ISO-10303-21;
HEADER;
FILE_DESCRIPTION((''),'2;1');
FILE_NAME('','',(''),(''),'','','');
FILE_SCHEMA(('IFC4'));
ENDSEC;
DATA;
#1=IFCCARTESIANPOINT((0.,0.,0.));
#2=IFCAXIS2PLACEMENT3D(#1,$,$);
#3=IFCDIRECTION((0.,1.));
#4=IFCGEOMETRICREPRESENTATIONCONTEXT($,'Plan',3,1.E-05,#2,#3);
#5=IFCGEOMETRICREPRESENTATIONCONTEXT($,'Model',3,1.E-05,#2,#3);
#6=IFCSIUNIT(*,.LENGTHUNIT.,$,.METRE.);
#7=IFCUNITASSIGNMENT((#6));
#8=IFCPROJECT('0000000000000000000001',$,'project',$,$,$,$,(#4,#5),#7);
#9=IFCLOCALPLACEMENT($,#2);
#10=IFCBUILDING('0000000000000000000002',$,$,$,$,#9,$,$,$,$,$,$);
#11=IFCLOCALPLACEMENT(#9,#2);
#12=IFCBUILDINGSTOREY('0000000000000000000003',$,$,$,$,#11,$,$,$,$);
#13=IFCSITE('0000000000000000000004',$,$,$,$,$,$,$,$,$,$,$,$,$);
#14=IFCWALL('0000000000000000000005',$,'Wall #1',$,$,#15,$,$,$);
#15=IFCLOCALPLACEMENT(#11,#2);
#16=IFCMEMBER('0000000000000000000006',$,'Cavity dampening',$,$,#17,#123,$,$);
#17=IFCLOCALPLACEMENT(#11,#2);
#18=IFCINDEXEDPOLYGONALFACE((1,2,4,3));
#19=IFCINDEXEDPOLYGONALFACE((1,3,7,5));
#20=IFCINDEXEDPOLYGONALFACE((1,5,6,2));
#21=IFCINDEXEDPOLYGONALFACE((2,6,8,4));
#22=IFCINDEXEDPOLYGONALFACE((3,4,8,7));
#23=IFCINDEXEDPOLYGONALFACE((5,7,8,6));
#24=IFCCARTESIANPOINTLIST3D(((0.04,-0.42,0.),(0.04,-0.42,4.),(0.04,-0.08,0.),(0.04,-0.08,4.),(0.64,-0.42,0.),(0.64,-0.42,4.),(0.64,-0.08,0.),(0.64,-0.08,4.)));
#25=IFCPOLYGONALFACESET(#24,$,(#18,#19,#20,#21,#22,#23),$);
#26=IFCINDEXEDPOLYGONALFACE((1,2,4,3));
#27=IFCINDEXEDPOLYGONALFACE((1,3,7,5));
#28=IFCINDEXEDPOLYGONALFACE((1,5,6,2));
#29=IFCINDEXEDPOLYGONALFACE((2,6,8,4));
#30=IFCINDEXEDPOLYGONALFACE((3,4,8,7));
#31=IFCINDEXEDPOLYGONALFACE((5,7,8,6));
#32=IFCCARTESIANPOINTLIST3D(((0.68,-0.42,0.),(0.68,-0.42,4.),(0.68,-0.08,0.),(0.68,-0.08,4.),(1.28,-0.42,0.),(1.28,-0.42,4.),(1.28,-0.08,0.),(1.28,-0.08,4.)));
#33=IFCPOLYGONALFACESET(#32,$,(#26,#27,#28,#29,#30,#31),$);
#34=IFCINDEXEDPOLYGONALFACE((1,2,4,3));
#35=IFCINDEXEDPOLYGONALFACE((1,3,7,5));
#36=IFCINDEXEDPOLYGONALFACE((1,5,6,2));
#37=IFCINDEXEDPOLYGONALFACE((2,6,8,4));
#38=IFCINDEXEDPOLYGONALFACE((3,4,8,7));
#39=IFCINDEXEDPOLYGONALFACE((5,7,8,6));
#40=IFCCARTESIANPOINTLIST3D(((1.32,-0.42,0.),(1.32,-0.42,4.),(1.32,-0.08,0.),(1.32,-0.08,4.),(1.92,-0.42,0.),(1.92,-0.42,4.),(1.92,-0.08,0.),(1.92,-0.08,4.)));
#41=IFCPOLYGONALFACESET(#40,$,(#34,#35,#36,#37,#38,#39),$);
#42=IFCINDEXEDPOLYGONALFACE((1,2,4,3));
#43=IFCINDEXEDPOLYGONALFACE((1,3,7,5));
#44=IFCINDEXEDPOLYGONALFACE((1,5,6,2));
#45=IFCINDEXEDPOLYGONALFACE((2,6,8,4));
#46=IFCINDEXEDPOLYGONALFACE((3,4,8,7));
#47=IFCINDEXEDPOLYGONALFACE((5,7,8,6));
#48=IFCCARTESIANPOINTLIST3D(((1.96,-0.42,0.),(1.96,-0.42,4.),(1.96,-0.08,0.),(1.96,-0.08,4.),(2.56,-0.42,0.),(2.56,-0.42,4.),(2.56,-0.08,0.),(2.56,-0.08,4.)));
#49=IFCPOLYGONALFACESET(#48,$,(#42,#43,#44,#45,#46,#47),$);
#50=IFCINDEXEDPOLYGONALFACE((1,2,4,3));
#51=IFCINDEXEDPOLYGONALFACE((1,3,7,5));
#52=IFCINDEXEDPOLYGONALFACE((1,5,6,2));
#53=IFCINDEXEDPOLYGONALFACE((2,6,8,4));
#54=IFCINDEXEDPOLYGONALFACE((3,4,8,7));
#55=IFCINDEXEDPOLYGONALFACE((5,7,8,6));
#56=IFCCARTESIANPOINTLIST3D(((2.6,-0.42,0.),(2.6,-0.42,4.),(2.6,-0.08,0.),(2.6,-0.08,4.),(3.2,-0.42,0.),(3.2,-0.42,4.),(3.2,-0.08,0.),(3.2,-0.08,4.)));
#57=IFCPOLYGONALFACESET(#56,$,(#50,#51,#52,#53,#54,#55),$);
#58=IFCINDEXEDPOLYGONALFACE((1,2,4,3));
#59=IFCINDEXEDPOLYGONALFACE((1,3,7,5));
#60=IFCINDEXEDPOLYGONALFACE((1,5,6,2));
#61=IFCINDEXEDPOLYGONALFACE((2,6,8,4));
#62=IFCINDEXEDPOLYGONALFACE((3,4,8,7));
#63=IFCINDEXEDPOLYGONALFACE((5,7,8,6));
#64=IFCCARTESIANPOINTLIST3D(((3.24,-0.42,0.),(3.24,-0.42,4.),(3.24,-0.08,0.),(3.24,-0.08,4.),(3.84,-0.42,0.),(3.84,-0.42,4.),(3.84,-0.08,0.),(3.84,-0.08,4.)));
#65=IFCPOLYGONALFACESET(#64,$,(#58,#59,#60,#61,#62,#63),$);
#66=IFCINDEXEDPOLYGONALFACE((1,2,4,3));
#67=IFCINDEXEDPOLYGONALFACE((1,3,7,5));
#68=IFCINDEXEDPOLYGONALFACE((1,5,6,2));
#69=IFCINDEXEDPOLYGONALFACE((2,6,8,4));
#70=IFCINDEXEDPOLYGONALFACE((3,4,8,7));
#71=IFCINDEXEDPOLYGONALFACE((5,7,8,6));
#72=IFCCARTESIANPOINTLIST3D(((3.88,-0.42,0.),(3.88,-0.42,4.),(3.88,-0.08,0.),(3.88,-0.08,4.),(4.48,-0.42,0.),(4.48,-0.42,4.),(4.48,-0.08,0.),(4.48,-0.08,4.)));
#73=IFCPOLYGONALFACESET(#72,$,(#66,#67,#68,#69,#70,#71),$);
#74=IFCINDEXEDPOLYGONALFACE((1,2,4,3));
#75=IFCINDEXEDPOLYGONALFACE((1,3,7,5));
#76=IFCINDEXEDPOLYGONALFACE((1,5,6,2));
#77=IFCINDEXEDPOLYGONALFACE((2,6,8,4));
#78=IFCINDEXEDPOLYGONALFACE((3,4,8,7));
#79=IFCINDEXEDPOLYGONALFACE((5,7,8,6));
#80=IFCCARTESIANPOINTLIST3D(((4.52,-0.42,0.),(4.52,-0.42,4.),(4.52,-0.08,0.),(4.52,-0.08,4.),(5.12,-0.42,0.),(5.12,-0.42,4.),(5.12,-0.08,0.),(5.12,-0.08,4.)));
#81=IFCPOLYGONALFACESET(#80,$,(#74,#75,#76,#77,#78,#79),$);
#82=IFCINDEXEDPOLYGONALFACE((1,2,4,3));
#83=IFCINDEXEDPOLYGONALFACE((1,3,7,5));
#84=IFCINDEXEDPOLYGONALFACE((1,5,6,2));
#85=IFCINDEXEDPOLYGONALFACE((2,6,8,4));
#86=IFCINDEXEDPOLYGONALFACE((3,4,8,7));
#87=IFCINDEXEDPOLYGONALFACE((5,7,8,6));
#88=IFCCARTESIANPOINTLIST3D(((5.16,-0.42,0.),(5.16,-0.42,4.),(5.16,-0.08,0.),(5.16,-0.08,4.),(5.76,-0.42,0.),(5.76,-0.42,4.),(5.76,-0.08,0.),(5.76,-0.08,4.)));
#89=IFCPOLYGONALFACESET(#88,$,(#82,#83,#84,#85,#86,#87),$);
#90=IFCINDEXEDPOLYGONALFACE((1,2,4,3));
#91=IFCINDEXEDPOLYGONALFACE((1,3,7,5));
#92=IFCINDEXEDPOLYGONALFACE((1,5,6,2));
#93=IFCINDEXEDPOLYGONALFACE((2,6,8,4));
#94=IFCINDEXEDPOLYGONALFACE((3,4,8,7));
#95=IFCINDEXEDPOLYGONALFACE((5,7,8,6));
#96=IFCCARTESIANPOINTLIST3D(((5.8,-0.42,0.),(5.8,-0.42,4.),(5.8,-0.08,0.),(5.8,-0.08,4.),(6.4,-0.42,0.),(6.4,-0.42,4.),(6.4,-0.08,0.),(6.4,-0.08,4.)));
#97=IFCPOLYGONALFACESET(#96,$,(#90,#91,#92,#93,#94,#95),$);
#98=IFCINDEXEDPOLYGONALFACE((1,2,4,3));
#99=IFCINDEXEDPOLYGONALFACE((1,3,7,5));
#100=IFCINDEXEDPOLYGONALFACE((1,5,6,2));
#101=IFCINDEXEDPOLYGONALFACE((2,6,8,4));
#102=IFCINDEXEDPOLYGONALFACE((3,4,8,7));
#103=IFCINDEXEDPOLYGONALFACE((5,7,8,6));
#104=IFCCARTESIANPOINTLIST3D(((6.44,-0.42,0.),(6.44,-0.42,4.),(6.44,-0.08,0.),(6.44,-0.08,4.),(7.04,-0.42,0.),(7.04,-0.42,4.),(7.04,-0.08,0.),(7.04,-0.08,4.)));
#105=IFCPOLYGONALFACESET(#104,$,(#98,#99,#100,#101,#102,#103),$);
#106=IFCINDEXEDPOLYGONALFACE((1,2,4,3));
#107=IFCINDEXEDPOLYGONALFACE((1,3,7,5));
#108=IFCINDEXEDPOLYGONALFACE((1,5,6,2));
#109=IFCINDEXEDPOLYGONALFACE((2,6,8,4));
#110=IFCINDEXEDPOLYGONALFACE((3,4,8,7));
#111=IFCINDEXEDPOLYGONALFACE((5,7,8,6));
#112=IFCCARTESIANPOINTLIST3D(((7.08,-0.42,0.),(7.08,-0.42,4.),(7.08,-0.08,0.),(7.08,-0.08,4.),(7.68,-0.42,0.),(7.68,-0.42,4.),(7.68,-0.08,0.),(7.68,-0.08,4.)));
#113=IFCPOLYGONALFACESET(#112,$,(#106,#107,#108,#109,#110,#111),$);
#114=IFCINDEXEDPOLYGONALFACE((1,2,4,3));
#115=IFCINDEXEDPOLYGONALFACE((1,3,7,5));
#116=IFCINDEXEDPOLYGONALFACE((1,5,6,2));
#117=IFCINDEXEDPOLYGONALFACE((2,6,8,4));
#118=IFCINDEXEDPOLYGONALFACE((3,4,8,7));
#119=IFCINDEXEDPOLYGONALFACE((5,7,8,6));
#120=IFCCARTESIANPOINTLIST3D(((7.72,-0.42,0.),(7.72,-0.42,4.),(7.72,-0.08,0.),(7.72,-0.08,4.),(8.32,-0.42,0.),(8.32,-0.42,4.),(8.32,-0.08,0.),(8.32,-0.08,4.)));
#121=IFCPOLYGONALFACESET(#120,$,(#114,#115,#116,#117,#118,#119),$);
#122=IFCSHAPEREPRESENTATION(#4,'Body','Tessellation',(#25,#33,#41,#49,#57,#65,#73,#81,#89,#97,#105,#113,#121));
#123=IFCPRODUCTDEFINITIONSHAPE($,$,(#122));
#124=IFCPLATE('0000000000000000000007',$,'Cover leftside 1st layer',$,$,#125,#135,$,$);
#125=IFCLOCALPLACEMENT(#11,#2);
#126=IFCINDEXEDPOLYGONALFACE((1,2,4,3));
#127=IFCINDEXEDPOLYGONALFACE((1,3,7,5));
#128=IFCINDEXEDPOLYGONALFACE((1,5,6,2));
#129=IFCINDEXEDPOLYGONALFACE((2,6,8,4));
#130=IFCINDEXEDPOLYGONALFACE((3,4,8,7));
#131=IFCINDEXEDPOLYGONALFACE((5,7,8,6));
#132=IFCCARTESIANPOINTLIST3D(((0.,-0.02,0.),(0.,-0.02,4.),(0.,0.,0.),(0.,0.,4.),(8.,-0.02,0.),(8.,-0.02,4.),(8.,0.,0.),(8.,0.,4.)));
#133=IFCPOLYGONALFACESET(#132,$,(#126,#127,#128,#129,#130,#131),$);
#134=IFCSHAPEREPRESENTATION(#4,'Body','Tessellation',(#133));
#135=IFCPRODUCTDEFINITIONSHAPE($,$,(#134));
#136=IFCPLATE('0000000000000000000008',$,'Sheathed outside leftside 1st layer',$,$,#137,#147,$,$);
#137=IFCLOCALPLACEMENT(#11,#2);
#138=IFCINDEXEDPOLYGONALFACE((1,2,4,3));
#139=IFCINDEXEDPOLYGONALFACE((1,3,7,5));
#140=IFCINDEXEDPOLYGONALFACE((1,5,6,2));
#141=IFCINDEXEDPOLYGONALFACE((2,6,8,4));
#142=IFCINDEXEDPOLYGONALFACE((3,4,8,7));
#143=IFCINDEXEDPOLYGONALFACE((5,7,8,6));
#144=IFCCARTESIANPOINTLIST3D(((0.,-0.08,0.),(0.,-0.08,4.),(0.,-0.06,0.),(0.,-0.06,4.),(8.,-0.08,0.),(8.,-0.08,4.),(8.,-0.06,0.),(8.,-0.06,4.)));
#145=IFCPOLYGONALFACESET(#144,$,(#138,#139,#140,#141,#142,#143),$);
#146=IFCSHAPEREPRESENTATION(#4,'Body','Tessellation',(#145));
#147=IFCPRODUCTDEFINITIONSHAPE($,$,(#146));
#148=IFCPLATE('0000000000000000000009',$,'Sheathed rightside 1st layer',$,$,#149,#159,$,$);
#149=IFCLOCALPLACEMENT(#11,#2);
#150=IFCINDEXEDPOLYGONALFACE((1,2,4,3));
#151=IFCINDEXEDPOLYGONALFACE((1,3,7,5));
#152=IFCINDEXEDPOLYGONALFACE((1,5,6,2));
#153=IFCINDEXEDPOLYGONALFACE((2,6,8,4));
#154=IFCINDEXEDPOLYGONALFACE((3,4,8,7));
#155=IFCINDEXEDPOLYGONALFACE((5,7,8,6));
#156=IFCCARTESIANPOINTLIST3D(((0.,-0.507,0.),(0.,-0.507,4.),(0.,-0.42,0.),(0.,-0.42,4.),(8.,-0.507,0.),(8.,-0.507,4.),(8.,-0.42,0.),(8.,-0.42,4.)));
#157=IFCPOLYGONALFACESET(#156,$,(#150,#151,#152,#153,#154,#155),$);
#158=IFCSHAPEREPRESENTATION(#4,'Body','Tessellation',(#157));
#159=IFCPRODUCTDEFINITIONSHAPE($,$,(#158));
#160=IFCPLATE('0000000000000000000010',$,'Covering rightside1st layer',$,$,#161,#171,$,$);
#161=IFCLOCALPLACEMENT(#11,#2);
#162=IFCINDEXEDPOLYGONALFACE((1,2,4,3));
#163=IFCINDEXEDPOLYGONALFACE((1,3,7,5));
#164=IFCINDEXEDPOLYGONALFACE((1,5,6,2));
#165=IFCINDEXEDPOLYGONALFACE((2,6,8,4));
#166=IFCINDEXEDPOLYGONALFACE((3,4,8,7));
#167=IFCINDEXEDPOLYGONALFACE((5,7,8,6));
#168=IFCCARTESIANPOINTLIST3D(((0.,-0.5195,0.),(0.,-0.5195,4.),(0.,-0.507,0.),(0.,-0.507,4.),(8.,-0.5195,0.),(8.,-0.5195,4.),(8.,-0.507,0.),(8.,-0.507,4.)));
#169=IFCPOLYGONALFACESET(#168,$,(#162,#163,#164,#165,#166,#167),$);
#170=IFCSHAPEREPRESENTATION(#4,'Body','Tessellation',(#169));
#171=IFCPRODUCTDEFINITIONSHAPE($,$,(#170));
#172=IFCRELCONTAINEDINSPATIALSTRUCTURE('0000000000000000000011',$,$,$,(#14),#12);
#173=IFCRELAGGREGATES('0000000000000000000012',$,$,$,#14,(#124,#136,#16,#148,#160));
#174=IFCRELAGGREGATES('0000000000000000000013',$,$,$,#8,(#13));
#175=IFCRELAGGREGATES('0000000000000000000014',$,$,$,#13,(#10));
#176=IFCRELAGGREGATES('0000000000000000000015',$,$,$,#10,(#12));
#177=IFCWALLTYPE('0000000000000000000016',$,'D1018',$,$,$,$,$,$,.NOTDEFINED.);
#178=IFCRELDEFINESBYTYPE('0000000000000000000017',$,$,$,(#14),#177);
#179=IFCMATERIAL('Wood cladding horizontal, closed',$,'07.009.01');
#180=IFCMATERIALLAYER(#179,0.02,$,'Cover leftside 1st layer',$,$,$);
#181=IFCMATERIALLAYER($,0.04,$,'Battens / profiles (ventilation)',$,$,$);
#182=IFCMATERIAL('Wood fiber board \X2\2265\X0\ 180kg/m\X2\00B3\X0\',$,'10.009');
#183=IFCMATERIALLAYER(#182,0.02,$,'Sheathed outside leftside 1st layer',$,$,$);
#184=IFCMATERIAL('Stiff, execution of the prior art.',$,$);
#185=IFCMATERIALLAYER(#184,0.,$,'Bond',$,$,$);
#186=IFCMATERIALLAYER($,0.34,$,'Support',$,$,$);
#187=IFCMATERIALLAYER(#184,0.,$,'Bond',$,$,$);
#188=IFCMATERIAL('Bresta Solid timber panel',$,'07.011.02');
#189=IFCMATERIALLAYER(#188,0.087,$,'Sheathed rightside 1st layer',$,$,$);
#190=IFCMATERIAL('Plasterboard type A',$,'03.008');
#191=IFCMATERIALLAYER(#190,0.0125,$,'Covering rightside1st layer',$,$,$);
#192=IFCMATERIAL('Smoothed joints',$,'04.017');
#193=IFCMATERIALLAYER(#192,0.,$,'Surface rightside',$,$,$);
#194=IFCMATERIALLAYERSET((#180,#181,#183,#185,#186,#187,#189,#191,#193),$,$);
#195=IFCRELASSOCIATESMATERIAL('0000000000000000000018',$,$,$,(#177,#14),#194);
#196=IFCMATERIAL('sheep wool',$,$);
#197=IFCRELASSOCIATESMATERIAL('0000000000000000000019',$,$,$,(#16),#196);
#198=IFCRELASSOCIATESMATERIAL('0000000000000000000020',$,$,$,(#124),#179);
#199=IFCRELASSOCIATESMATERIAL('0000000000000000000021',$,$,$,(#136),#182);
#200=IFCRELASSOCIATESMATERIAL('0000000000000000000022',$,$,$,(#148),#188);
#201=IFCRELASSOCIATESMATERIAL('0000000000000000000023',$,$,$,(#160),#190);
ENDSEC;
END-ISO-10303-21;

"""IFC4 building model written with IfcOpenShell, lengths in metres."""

from ifc_helpers import new_model, si_unit, direction, frame, frame_2d, origin, origin_with_axes, place, context, project, spatial, rectangle, extrude, material, layer, layer_set, type_object, element, aggregate, save


model = new_model("IFC4")

# Units and contexts
plan_context = context("Plan", 3, precision=1e-05, world=origin(), true_north=direction((0.0, 1.0)))
model_context = context("Model", 3, precision=1e-05, world=origin(), true_north=direction((0.0, 1.0)))
ifc_project = project(units=[si_unit("LENGTHUNIT", "METRE")], contexts=[plan_context, model_context])

# Site, building, storey
site = spatial("IfcSite", under=ifc_project)
building_placement = place(None, origin())
building = spatial("IfcBuilding", under=site, at=building_placement)
storey_placement = place(building_placement, origin())
storey = spatial("IfcBuildingStorey", under=building, at=storey_placement)

# Wall, member, plates
ifc_material_1 = material(Name="Wood cladding horizontal, closed", Category="07.009.01")
ifc_layer_1 = layer(ifc_material_1, 0.02, Name="Cover leftside 1st layer")
ifc_layer_2 = layer(None, 0.04, Name="Battens / profiles (ventilation)")
ifc_material_2 = material(Name="Wood fiber board ≥ 180kg/m³", Category="10.009")
ifc_layer_3 = layer(ifc_material_2, 0.02, Name="Sheathed outside leftside 1st layer")
ifc_material_3 = material(Name="Stiff, execution of the prior art.")
ifc_layer_4 = layer(ifc_material_3, 0.0, Name="Bond")
ifc_layer_5 = layer(None, 0.34, Name="Support")
ifc_layer_6 = layer(ifc_material_3, 0.0, Name="Bond")
ifc_material_4 = material(Name="Bresta Solid timber panel", Category="07.011.02")
ifc_layer_7 = layer(ifc_material_4, 0.087, Name="Sheathed rightside 1st layer")
ifc_material_5 = material(Name="Plasterboard type A", Category="03.008")
ifc_layer_8 = layer(ifc_material_5, 0.0125, Name="Covering rightside1st layer")
ifc_material_6 = material(Name="Smoothed joints", Category="04.017")
ifc_layer_9 = layer(ifc_material_6, 0.0, Name="Surface rightside")
ifc_layer_set = layer_set([ifc_layer_1, ifc_layer_2, ifc_layer_3, ifc_layer_4, ifc_layer_5, ifc_layer_6, ifc_layer_7, ifc_layer_8, ifc_layer_9])
wall_type = type_object("IfcWallType", Name="D1018", PredefinedType="NOTDEFINED", material=ifc_layer_set)
wall_placement = place(None, frame((0.0, 0.0, 0.0), z_axis=(0.0, -1.0, 0.0), x_axis=(1.0, 0.0, 0.0)))
wall = element("IfcWall", 1, at=wall_placement, inside=storey, type_object=wall_type, material=ifc_layer_set, Name="Wall #1")
ifc_material_7 = material(Name="sheep wool")
member_1_placement = place(wall_placement, origin())
member_1 = element("IfcMember", 2, at=member_1_placement, material=ifc_material_7, Name="Cavity dampening", context=plan_context, shape_type="SweptSolid", body=[
    extrude(rectangle(XDim=0.6, YDim=0.34, at=frame_2d((0.3, 0.17), x_axis=(1.0, 0.0))), frame((0.04, 4.0, 0.08), z_axis=(0.0, -1.0, 0.0), x_axis=(1.0, 0.0, 0.0)), (0.0, 0.0, 1.0), 4.0),
    extrude(rectangle(XDim=0.6, YDim=0.34, at=frame_2d((0.3, 0.17), x_axis=(1.0, 0.0))), frame((0.68, 4.0, 0.08), z_axis=(0.0, -1.0, 0.0), x_axis=(1.0, 0.0, 0.0)), (0.0, 0.0, 1.0), 4.0),
    extrude(rectangle(XDim=0.6, YDim=0.34, at=frame_2d((0.3, 0.17), x_axis=(1.0, 0.0))), frame((1.32, 4.0, 0.08), z_axis=(0.0, -1.0, 0.0), x_axis=(1.0, 0.0, 0.0)), (0.0, 0.0, 1.0), 4.0),
    extrude(rectangle(XDim=0.6, YDim=0.34, at=frame_2d((0.3, 0.17), x_axis=(1.0, 0.0))), frame((1.96, 4.0, 0.08), z_axis=(0.0, -1.0, 0.0), x_axis=(1.0, 0.0, 0.0)), (0.0, 0.0, 1.0), 4.0),
    extrude(rectangle(XDim=0.6, YDim=0.34, at=frame_2d((0.3, 0.17), x_axis=(1.0, 0.0))), frame((2.6, 4.0, 0.08), z_axis=(0.0, -1.0, 0.0), x_axis=(1.0, 0.0, 0.0)), (0.0, 0.0, 1.0), 4.0),
    extrude(rectangle(XDim=0.6, YDim=0.34, at=frame_2d((0.3, 0.17), x_axis=(1.0, 0.0))), frame((3.24, 4.0, 0.08), z_axis=(0.0, -1.0, 0.0), x_axis=(1.0, 0.0, 0.0)), (0.0, 0.0, 1.0), 4.0),
    extrude(rectangle(XDim=0.6, YDim=0.34, at=frame_2d((0.3, 0.17), x_axis=(1.0, 0.0))), frame((3.88, 4.0, 0.08), z_axis=(0.0, -1.0, 0.0), x_axis=(1.0, 0.0, 0.0)), (0.0, 0.0, 1.0), 4.0),
    extrude(rectangle(XDim=0.6, YDim=0.34, at=frame_2d((0.3, 0.17), x_axis=(1.0, 0.0))), frame((4.52, 4.0, 0.08), z_axis=(0.0, -1.0, 0.0), x_axis=(1.0, 0.0, 0.0)), (0.0, 0.0, 1.0), 4.0),
    extrude(rectangle(XDim=0.6, YDim=0.34, at=frame_2d((0.3, 0.17), x_axis=(1.0, 0.0))), frame((5.16, 4.0, 0.08), z_axis=(0.0, -1.0, 0.0), x_axis=(1.0, 0.0, 0.0)), (0.0, 0.0, 1.0), 4.0),
    extrude(rectangle(XDim=0.6, YDim=0.34, at=frame_2d((0.3, 0.17), x_axis=(1.0, 0.0))), frame((5.8, 4.0, 0.08), z_axis=(0.0, -1.0, 0.0), x_axis=(1.0, 0.0, 0.0)), (0.0, 0.0, 1.0), 4.0),
    extrude(rectangle(XDim=0.6, YDim=0.34, at=frame_2d((0.3, 0.17), x_axis=(1.0, 0.0))), frame((6.44, 4.0, 0.08), z_axis=(0.0, -1.0, 0.0), x_axis=(1.0, 0.0, 0.0)), (0.0, 0.0, 1.0), 4.0),
    extrude(rectangle(XDim=0.6, YDim=0.34, at=frame_2d((0.3, 0.17), x_axis=(1.0, 0.0))), frame((7.08, 4.0, 0.08), z_axis=(0.0, -1.0, 0.0), x_axis=(1.0, 0.0, 0.0)), (0.0, 0.0, 1.0), 4.0),
    extrude(rectangle(XDim=0.6, YDim=0.34, at=frame_2d((0.3, 0.17), x_axis=(1.0, 0.0))), frame((7.72, 4.0, 0.08), z_axis=(0.0, -1.0, 0.0), x_axis=(1.0, 0.0, 0.0)), (0.0, 0.0, 1.0), 4.0),
])
plate_1_placement = place(wall_placement, origin())
plate_1 = element("IfcPlate", 3, at=plate_1_placement, material=ifc_material_1, Name="Cover leftside 1st layer", context=plan_context, shape_type="SweptSolid", body=[
    extrude(rectangle(XDim=8.0, YDim=4.0, at=frame_2d((4.0, 2.0), x_axis=(1.0, 0.0))), origin_with_axes(), (0.0, 0.0, 1.0), 0.02),
])
plate_2_placement = place(wall_placement, origin())
plate_2 = element("IfcPlate", 4, at=plate_2_placement, material=ifc_material_2, Name="Sheathed outside leftside 1st layer", context=plan_context, shape_type="SweptSolid", body=[
    extrude(rectangle(XDim=8.0, YDim=4.0, at=frame_2d((4.0, 2.0), x_axis=(1.0, 0.0))), frame((0.0, 0.0, 0.06), z_axis=(0.0, 0.0, 1.0), x_axis=(1.0, 0.0, 0.0)), (0.0, 0.0, 1.0), 0.02),
])
plate_3_placement = place(wall_placement, origin())
plate_3 = element("IfcPlate", 5, at=plate_3_placement, material=ifc_material_4, Name="Sheathed rightside 1st layer", context=plan_context, shape_type="SweptSolid", body=[
    extrude(rectangle(XDim=8.0, YDim=4.0, at=frame_2d((4.0, 2.0), x_axis=(1.0, 0.0))), frame((0.0, 0.0, 0.42), z_axis=(0.0, 0.0, 1.0), x_axis=(1.0, 0.0, 0.0)), (0.0, 0.0, 1.0), 0.087),
])
plate_4_placement = place(wall_placement, origin())
plate_4 = element("IfcPlate", 6, at=plate_4_placement, material=ifc_material_5, Name="Covering rightside1st layer", context=plan_context, shape_type="SweptSolid", body=[
    extrude(rectangle(XDim=8.0, YDim=4.0, at=frame_2d((4.0, 2.0), x_axis=(1.0, 0.0))), frame((0.0, 0.0, 0.507), z_axis=(0.0, 0.0, 1.0), x_axis=(1.0, 0.0, 0.0)), (0.0, 0.0, 1.0), 0.0125),
])
aggregate(wall, [plate_1, plate_2, member_1, plate_3, plate_4])

save(model, "model.ifc")
